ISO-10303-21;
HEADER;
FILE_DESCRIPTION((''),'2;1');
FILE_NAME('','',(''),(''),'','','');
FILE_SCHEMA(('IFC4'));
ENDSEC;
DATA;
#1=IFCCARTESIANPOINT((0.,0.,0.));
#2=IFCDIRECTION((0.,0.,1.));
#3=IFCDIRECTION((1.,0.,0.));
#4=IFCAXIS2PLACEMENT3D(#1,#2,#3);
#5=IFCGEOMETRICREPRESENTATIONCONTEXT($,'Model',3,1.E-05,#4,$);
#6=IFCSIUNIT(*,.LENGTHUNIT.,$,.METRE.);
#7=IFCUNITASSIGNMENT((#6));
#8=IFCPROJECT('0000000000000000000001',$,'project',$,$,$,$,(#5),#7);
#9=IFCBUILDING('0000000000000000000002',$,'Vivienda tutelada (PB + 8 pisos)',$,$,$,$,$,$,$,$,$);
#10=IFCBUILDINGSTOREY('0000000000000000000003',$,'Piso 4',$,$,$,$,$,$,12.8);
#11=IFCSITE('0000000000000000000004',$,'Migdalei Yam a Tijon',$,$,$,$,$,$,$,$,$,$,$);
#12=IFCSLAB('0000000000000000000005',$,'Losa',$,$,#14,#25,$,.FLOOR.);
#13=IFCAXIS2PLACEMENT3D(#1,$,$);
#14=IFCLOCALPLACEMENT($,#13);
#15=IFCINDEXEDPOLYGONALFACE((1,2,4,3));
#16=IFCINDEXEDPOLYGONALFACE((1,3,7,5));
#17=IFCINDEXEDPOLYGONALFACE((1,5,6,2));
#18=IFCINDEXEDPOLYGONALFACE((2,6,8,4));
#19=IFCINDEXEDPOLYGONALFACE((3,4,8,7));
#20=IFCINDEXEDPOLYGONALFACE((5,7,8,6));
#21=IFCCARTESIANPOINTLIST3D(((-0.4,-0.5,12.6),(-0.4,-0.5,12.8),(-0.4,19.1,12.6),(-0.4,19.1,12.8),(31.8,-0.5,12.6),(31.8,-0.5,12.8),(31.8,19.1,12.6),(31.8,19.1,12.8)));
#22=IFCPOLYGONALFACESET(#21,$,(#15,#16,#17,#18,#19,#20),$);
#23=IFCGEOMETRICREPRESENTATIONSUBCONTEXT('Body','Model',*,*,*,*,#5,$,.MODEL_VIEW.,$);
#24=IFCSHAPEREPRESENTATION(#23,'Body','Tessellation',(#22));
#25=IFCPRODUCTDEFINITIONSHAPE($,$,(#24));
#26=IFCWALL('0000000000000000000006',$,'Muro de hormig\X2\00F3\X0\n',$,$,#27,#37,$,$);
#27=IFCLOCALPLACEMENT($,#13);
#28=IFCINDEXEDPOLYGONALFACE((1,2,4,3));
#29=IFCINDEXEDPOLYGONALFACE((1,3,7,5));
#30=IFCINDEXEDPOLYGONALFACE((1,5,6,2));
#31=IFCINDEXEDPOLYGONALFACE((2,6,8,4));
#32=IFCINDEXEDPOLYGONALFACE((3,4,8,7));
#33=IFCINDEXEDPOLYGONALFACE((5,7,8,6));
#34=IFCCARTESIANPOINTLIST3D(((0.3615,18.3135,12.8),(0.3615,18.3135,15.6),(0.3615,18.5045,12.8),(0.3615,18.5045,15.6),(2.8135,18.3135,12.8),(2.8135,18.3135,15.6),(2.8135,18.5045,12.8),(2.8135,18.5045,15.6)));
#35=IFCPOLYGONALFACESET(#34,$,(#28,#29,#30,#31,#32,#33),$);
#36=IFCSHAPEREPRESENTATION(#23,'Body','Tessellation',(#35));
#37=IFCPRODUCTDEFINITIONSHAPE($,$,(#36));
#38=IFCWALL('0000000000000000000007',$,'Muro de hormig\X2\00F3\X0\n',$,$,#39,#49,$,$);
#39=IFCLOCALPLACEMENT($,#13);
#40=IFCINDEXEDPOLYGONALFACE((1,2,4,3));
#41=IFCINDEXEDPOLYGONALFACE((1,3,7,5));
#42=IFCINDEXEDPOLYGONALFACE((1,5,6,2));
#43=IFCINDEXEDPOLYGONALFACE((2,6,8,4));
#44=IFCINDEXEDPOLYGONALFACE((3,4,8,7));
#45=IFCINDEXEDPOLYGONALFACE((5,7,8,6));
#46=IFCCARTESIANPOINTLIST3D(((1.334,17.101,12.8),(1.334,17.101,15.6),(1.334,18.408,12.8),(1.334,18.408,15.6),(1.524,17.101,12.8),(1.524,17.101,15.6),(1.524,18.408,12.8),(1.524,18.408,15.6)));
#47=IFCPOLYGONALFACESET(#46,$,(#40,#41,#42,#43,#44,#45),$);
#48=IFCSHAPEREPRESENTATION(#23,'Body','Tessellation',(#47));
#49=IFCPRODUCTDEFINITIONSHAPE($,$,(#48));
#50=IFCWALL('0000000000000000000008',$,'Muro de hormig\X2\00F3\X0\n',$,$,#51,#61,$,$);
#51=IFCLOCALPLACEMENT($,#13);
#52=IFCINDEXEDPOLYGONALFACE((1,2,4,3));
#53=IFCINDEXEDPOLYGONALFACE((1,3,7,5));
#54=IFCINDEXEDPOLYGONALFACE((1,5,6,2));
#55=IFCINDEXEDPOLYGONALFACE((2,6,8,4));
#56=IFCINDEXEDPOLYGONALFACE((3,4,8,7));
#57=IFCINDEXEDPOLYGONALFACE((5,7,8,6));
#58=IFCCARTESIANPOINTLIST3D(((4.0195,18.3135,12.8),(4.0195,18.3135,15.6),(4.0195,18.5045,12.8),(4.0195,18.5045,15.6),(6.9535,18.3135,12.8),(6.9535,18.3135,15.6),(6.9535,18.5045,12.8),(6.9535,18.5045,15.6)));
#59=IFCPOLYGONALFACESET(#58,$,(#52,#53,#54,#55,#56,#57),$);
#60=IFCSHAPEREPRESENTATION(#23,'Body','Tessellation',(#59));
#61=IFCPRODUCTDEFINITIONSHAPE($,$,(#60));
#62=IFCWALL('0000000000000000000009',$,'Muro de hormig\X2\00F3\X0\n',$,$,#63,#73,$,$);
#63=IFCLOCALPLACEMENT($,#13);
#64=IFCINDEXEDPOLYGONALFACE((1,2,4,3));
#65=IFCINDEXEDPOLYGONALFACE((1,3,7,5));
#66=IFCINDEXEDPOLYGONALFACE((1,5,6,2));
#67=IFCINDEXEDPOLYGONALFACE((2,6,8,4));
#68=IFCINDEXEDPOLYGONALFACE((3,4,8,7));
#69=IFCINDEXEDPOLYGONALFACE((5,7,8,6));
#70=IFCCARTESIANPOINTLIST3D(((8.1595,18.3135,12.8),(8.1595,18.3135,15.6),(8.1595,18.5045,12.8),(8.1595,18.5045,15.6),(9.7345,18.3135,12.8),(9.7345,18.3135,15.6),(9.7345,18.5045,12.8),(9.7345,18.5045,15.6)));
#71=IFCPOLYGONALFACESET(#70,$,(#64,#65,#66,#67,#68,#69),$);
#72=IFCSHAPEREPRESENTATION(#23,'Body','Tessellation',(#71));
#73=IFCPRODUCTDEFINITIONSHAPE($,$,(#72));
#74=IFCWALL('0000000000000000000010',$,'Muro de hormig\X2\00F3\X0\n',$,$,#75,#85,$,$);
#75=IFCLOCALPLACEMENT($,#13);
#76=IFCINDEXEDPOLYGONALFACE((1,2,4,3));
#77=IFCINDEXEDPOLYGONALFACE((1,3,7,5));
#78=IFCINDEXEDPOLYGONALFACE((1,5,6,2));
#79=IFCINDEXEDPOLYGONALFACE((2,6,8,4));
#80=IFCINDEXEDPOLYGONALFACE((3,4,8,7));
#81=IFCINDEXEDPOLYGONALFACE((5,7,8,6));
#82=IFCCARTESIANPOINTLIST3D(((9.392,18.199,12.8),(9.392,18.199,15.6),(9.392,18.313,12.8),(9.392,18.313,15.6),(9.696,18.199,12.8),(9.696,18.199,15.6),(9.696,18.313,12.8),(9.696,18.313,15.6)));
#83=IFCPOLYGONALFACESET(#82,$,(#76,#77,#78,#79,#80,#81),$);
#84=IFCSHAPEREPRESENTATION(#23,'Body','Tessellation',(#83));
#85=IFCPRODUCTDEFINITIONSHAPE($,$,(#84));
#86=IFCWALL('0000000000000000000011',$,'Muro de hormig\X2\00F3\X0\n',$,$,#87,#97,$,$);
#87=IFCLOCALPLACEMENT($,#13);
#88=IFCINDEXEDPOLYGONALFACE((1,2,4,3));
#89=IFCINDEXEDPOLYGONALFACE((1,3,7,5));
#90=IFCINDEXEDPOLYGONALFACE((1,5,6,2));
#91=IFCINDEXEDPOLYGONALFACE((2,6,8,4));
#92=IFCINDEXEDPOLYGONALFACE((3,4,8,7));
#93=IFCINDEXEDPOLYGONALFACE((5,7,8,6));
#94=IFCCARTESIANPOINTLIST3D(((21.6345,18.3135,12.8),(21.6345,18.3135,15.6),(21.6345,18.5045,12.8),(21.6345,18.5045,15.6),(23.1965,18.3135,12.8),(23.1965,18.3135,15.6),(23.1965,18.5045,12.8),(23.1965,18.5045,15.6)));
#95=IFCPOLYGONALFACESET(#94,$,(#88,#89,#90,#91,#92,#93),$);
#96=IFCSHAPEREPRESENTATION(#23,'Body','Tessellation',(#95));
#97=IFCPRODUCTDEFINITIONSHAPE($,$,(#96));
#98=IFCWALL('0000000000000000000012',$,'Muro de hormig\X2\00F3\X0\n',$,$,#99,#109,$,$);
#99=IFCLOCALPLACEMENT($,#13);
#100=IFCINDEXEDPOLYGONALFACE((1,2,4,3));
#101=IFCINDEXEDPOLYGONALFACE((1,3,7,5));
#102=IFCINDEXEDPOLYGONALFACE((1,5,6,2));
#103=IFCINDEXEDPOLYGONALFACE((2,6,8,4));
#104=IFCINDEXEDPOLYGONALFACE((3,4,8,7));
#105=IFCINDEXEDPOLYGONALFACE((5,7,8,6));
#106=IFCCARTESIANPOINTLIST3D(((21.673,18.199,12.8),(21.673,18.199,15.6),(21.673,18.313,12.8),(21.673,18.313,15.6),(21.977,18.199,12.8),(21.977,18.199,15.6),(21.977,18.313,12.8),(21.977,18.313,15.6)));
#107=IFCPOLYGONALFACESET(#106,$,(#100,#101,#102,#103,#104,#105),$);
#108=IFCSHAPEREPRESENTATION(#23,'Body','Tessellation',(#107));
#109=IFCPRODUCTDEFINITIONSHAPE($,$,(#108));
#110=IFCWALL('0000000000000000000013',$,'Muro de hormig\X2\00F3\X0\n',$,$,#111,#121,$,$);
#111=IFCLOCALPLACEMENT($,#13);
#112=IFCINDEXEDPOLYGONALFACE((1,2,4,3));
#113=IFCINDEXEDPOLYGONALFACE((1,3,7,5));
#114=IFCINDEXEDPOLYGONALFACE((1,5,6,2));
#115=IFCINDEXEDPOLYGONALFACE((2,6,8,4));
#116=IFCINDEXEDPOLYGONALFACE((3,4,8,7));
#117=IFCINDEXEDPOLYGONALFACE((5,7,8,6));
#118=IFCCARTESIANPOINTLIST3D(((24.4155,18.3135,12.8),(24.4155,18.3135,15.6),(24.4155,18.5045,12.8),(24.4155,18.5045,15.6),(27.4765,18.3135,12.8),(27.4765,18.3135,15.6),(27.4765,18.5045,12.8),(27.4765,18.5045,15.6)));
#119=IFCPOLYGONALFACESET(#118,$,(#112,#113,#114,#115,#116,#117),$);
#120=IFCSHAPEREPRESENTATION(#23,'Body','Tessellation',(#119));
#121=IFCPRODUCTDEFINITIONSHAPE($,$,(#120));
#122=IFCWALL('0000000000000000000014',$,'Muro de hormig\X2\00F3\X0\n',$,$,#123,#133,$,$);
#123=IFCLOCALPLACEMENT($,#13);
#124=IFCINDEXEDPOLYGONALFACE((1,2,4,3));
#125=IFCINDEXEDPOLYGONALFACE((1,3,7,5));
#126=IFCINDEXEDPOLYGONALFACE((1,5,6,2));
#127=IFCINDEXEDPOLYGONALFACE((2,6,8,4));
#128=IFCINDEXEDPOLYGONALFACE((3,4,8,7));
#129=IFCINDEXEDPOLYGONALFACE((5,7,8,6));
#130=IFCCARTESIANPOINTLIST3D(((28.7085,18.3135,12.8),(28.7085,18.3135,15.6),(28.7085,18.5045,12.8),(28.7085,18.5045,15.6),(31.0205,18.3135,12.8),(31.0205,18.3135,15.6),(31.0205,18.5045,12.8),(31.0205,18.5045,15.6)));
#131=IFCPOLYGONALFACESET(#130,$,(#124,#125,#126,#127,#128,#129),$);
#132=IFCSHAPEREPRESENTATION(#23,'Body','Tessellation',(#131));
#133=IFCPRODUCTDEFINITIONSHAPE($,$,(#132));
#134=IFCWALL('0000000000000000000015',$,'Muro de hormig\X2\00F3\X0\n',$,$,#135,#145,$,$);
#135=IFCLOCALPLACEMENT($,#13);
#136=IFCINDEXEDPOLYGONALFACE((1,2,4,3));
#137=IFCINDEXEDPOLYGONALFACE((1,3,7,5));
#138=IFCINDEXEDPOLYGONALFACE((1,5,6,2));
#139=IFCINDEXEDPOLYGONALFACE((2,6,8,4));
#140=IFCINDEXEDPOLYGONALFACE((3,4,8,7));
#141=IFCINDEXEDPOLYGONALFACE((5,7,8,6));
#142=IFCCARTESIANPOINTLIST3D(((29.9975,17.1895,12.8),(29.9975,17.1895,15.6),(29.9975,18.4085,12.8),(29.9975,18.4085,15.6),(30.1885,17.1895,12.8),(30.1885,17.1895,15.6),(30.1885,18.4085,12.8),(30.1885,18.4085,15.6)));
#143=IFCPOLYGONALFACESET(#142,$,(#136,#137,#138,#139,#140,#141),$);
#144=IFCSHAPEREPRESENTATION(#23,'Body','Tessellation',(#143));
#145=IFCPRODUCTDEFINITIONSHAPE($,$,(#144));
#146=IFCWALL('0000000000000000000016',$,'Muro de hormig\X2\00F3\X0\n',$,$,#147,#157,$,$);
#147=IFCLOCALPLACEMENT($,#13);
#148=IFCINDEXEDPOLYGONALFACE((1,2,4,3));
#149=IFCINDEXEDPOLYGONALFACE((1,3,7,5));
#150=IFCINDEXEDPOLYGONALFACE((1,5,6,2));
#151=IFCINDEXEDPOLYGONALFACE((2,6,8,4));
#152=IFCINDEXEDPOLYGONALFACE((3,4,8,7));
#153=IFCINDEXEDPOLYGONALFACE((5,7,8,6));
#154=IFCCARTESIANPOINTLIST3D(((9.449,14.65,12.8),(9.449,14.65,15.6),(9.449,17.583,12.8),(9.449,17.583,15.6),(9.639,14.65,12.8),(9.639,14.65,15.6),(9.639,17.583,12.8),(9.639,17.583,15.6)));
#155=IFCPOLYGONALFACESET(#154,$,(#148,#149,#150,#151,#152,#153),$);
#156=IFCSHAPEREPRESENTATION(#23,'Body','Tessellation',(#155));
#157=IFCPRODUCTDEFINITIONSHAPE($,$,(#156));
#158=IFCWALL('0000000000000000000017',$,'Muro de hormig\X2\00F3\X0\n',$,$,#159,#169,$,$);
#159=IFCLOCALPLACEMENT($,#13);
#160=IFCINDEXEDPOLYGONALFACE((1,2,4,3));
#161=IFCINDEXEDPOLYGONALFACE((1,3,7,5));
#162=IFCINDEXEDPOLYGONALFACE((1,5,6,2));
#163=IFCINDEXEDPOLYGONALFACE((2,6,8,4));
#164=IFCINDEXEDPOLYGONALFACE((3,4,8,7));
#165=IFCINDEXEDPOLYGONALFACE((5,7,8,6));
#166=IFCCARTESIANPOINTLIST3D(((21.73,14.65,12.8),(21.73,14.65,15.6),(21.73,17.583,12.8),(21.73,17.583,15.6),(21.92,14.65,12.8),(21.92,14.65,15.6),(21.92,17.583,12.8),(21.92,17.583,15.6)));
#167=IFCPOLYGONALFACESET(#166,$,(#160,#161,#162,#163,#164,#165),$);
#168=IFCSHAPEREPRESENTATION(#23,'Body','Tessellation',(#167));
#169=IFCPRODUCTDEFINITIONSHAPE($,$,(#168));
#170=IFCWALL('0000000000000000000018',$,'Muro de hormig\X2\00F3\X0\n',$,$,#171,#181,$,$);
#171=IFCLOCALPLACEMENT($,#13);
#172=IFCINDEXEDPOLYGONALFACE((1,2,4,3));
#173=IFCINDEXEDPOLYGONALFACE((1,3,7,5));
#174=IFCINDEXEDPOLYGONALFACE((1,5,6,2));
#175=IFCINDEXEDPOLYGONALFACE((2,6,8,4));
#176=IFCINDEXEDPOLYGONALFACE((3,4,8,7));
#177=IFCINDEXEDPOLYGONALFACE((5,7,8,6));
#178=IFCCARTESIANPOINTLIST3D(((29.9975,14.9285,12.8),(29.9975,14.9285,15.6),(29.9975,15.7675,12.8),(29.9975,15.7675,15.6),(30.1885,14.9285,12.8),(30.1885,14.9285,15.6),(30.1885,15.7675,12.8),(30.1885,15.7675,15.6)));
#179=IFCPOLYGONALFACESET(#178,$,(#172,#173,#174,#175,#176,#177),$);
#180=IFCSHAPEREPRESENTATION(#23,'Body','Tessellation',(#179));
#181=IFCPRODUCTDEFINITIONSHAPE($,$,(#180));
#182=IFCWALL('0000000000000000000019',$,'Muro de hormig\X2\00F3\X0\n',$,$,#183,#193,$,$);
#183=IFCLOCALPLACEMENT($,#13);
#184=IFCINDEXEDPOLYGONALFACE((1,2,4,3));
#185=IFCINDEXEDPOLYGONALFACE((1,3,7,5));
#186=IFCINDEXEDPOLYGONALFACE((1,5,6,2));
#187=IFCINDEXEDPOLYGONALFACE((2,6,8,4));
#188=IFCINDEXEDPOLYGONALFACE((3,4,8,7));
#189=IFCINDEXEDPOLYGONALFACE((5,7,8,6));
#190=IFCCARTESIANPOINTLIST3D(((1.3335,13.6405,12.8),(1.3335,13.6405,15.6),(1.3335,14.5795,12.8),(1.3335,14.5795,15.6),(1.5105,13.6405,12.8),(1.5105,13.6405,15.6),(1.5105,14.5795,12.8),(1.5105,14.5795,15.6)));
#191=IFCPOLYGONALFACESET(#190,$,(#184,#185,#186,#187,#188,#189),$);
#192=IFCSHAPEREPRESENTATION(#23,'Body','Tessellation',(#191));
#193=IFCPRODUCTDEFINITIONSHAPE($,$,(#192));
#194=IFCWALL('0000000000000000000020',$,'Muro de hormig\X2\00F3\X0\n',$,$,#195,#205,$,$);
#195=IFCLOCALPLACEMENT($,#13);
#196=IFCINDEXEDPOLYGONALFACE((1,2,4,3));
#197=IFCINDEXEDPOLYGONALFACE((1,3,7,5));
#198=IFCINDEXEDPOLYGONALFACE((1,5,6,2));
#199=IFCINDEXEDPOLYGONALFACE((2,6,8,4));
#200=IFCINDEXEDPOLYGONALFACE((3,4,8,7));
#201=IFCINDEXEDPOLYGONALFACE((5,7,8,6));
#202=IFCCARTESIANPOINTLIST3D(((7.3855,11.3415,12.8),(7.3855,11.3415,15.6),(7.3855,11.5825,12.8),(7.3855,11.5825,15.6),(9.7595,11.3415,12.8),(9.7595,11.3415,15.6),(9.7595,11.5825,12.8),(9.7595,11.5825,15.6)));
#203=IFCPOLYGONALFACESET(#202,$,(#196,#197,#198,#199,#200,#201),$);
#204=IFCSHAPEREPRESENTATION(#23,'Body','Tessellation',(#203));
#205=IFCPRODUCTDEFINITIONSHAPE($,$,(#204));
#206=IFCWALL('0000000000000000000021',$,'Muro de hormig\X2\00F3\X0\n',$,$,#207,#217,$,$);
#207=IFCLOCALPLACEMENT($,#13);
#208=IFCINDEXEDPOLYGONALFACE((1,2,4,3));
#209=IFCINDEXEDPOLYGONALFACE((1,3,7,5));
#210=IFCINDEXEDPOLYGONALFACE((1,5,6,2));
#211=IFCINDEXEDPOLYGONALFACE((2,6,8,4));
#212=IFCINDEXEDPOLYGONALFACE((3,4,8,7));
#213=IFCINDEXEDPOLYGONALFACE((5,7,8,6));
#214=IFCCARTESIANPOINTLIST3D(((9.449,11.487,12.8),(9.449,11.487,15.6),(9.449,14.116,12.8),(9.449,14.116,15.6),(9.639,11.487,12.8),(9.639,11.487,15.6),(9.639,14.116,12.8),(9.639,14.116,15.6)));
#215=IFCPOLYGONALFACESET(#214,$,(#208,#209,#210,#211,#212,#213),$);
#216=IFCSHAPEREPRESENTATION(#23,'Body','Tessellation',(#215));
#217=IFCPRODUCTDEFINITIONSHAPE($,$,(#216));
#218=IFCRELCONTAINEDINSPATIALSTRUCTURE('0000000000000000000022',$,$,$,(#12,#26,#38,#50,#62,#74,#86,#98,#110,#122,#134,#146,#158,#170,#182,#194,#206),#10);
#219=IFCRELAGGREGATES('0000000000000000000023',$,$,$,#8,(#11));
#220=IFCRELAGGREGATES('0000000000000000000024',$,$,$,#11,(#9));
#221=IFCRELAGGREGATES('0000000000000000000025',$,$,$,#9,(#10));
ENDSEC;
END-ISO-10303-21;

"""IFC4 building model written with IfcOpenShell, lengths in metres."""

from ifc_helpers import new_model, si_unit, frame, origin_with_axes, context, subcontext, project, spatial, line, indexed_curve, outline, extrude, element, save


model = new_model("IFC4")

# Units and contexts
model_context = context("Model", 3, precision=1e-05, world=origin_with_axes())
body_context = subcontext(model_context, "Body", "Model", "MODEL_VIEW")
ifc_project = project(units=[si_unit("LENGTHUNIT", "METRE")], contexts=[model_context])

# Site, building, storey
site = spatial("IfcSite", under=ifc_project, Name="Migdalei Yam a Tijon")
building = spatial("IfcBuilding", under=site, Name="Vivienda tutelada (PB + 8 pisos)")
storey = spatial("IfcBuildingStorey", under=building, Name="Piso 4", Elevation=12.8)

# Slab
element("IfcSlab", 1, inside=storey, Name="Losa", PredefinedType="FLOOR", context=body_context, shape_type="SweptSolid", body=[
    extrude(outline(indexed_curve([(0.0, 0.0), (32.2, 0.0), (32.2, 19.6), (0.0, 19.6)], segments=[line(1, 2, 3, 4, 1)])), frame((-0.4, -0.5, 12.6), z_axis=(0.0, 0.0, 1.0), x_axis=(1.0, 0.0, 0.0)), (0.0, 0.0, 1.0), 0.2),
])

# Walls
element("IfcWall", 2, inside=storey, Name="Muro de hormigón", context=body_context, shape_type="SweptSolid", body=[
    extrude(outline(indexed_curve([(0.0, 0.0), (2.452, 0.0), (2.452, 0.191), (0.0, 0.191)], segments=[line(1, 2, 3, 4, 1)])), frame((0.3615, 18.3135, 12.8), z_axis=(0.0, 0.0, 1.0), x_axis=(1.0, 0.0, 0.0)), (0.0, 0.0, 1.0), 2.8),
])
element("IfcWall", 3, inside=storey, Name="Muro de hormigón", context=body_context, shape_type="SweptSolid", body=[
    extrude(outline(indexed_curve([(0.0, 0.0), (0.19, 0.0), (0.19, 1.307), (0.0, 1.307)], segments=[line(1, 2, 3, 4, 1)])), frame((1.334, 17.101, 12.8), z_axis=(0.0, 0.0, 1.0), x_axis=(1.0, 0.0, 0.0)), (0.0, 0.0, 1.0), 2.8),
])
element("IfcWall", 4, inside=storey, Name="Muro de hormigón", context=body_context, shape_type="SweptSolid", body=[
    extrude(outline(indexed_curve([(0.0, 0.0), (2.934, 0.0), (2.934, 0.191), (0.0, 0.191)], segments=[line(1, 2, 3, 4, 1)])), frame((4.0195, 18.3135, 12.8), z_axis=(0.0, 0.0, 1.0), x_axis=(1.0, 0.0, 0.0)), (0.0, 0.0, 1.0), 2.8),
])
element("IfcWall", 5, inside=storey, Name="Muro de hormigón", context=body_context, shape_type="SweptSolid", body=[
    extrude(outline(indexed_curve([(0.0, 0.0), (1.575, 0.0), (1.575, 0.191), (0.0, 0.191)], segments=[line(1, 2, 3, 4, 1)])), frame((8.1595, 18.3135, 12.8), z_axis=(0.0, 0.0, 1.0), x_axis=(1.0, 0.0, 0.0)), (0.0, 0.0, 1.0), 2.8),
])
element("IfcWall", 6, inside=storey, Name="Muro de hormigón", context=body_context, shape_type="SweptSolid", body=[
    extrude(outline(indexed_curve([(0.0, 0.0), (0.304, 0.0), (0.304, 0.114), (0.0, 0.114)], segments=[line(1, 2, 3, 4, 1)])), frame((9.392, 18.199, 12.8), z_axis=(0.0, 0.0, 1.0), x_axis=(1.0, 0.0, 0.0)), (0.0, 0.0, 1.0), 2.8),
])
element("IfcWall", 7, inside=storey, Name="Muro de hormigón", context=body_context, shape_type="SweptSolid", body=[
    extrude(outline(indexed_curve([(0.0, 0.0), (1.562, 0.0), (1.562, 0.191), (0.0, 0.191)], segments=[line(1, 2, 3, 4, 1)])), frame((21.6345, 18.3135, 12.8), z_axis=(0.0, 0.0, 1.0), x_axis=(1.0, 0.0, 0.0)), (0.0, 0.0, 1.0), 2.8),
])
element("IfcWall", 8, inside=storey, Name="Muro de hormigón", context=body_context, shape_type="SweptSolid", body=[
    extrude(outline(indexed_curve([(0.0, 0.0), (0.304, 0.0), (0.304, 0.114), (0.0, 0.114)], segments=[line(1, 2, 3, 4, 1)])), frame((21.673, 18.199, 12.8), z_axis=(0.0, 0.0, 1.0), x_axis=(1.0, 0.0, 0.0)), (0.0, 0.0, 1.0), 2.8),
])
element("IfcWall", 9, inside=storey, Name="Muro de hormigón", context=body_context, shape_type="SweptSolid", body=[
    extrude(outline(indexed_curve([(0.0, 0.0), (3.061, 0.0), (3.061, 0.191), (0.0, 0.191)], segments=[line(1, 2, 3, 4, 1)])), frame((24.4155, 18.3135, 12.8), z_axis=(0.0, 0.0, 1.0), x_axis=(1.0, 0.0, 0.0)), (0.0, 0.0, 1.0), 2.8),
])
element("IfcWall", 10, inside=storey, Name="Muro de hormigón", context=body_context, shape_type="SweptSolid", body=[
    extrude(outline(indexed_curve([(0.0, 0.0), (2.312, 0.0), (2.312, 0.191), (0.0, 0.191)], segments=[line(1, 2, 3, 4, 1)])), frame((28.7085, 18.3135, 12.8), z_axis=(0.0, 0.0, 1.0), x_axis=(1.0, 0.0, 0.0)), (0.0, 0.0, 1.0), 2.8),
])
element("IfcWall", 11, inside=storey, Name="Muro de hormigón", context=body_context, shape_type="SweptSolid", body=[
    extrude(outline(indexed_curve([(0.0, 0.0), (0.191, 0.0), (0.191, 1.219), (0.0, 1.219)], segments=[line(1, 2, 3, 4, 1)])), frame((29.9975, 17.1895, 12.8), z_axis=(0.0, 0.0, 1.0), x_axis=(1.0, 0.0, 0.0)), (0.0, 0.0, 1.0), 2.8),
])
element("IfcWall", 12, inside=storey, Name="Muro de hormigón", context=body_context, shape_type="SweptSolid", body=[
    extrude(outline(indexed_curve([(0.0, 0.0), (0.19, 0.0), (0.19, 2.933), (0.0, 2.933)], segments=[line(1, 2, 3, 4, 1)])), frame((9.449, 14.65, 12.8), z_axis=(0.0, 0.0, 1.0), x_axis=(1.0, 0.0, 0.0)), (0.0, 0.0, 1.0), 2.8),
])
element("IfcWall", 13, inside=storey, Name="Muro de hormigón", context=body_context, shape_type="SweptSolid", body=[
    extrude(outline(indexed_curve([(0.0, 0.0), (0.19, 0.0), (0.19, 2.933), (0.0, 2.933)], segments=[line(1, 2, 3, 4, 1)])), frame((21.73, 14.65, 12.8), z_axis=(0.0, 0.0, 1.0), x_axis=(1.0, 0.0, 0.0)), (0.0, 0.0, 1.0), 2.8),
])
element("IfcWall", 14, inside=storey, Name="Muro de hormigón", context=body_context, shape_type="SweptSolid", body=[
    extrude(outline(indexed_curve([(0.0, 0.0), (0.191, 0.0), (0.191, 0.839), (0.0, 0.839)], segments=[line(1, 2, 3, 4, 1)])), frame((29.9975, 14.9285, 12.8), z_axis=(0.0, 0.0, 1.0), x_axis=(1.0, 0.0, 0.0)), (0.0, 0.0, 1.0), 2.8),
])
element("IfcWall", 15, inside=storey, Name="Muro de hormigón", context=body_context, shape_type="SweptSolid", body=[
    extrude(outline(indexed_curve([(0.0, 0.0), (0.177, 0.0), (0.177, 0.939), (0.0, 0.939)], segments=[line(1, 2, 3, 4, 1)])), frame((1.3335, 13.6405, 12.8), z_axis=(0.0, 0.0, 1.0), x_axis=(1.0, 0.0, 0.0)), (0.0, 0.0, 1.0), 2.8),
])
element("IfcWall", 16, inside=storey, Name="Muro de hormigón", context=body_context, shape_type="SweptSolid", body=[
    extrude(outline(indexed_curve([(0.0, 0.0), (2.374, 0.0), (2.374, 0.241), (0.0, 0.241)], segments=[line(1, 2, 3, 4, 1)])), frame((7.3855, 11.3415, 12.8), z_axis=(0.0, 0.0, 1.0), x_axis=(1.0, 0.0, 0.0)), (0.0, 0.0, 1.0), 2.8),
])
element("IfcWall", 17, inside=storey, Name="Muro de hormigón", context=body_context, shape_type="SweptSolid", body=[
    extrude(outline(indexed_curve([(0.0, 0.0), (0.19, 0.0), (0.19, 2.629), (0.0, 2.629)], segments=[line(1, 2, 3, 4, 1)])), frame((9.449, 11.487, 12.8), z_axis=(0.0, 0.0, 1.0), x_axis=(1.0, 0.0, 0.0)), (0.0, 0.0, 1.0), 2.8),
])

save(model, "model.ifc")
